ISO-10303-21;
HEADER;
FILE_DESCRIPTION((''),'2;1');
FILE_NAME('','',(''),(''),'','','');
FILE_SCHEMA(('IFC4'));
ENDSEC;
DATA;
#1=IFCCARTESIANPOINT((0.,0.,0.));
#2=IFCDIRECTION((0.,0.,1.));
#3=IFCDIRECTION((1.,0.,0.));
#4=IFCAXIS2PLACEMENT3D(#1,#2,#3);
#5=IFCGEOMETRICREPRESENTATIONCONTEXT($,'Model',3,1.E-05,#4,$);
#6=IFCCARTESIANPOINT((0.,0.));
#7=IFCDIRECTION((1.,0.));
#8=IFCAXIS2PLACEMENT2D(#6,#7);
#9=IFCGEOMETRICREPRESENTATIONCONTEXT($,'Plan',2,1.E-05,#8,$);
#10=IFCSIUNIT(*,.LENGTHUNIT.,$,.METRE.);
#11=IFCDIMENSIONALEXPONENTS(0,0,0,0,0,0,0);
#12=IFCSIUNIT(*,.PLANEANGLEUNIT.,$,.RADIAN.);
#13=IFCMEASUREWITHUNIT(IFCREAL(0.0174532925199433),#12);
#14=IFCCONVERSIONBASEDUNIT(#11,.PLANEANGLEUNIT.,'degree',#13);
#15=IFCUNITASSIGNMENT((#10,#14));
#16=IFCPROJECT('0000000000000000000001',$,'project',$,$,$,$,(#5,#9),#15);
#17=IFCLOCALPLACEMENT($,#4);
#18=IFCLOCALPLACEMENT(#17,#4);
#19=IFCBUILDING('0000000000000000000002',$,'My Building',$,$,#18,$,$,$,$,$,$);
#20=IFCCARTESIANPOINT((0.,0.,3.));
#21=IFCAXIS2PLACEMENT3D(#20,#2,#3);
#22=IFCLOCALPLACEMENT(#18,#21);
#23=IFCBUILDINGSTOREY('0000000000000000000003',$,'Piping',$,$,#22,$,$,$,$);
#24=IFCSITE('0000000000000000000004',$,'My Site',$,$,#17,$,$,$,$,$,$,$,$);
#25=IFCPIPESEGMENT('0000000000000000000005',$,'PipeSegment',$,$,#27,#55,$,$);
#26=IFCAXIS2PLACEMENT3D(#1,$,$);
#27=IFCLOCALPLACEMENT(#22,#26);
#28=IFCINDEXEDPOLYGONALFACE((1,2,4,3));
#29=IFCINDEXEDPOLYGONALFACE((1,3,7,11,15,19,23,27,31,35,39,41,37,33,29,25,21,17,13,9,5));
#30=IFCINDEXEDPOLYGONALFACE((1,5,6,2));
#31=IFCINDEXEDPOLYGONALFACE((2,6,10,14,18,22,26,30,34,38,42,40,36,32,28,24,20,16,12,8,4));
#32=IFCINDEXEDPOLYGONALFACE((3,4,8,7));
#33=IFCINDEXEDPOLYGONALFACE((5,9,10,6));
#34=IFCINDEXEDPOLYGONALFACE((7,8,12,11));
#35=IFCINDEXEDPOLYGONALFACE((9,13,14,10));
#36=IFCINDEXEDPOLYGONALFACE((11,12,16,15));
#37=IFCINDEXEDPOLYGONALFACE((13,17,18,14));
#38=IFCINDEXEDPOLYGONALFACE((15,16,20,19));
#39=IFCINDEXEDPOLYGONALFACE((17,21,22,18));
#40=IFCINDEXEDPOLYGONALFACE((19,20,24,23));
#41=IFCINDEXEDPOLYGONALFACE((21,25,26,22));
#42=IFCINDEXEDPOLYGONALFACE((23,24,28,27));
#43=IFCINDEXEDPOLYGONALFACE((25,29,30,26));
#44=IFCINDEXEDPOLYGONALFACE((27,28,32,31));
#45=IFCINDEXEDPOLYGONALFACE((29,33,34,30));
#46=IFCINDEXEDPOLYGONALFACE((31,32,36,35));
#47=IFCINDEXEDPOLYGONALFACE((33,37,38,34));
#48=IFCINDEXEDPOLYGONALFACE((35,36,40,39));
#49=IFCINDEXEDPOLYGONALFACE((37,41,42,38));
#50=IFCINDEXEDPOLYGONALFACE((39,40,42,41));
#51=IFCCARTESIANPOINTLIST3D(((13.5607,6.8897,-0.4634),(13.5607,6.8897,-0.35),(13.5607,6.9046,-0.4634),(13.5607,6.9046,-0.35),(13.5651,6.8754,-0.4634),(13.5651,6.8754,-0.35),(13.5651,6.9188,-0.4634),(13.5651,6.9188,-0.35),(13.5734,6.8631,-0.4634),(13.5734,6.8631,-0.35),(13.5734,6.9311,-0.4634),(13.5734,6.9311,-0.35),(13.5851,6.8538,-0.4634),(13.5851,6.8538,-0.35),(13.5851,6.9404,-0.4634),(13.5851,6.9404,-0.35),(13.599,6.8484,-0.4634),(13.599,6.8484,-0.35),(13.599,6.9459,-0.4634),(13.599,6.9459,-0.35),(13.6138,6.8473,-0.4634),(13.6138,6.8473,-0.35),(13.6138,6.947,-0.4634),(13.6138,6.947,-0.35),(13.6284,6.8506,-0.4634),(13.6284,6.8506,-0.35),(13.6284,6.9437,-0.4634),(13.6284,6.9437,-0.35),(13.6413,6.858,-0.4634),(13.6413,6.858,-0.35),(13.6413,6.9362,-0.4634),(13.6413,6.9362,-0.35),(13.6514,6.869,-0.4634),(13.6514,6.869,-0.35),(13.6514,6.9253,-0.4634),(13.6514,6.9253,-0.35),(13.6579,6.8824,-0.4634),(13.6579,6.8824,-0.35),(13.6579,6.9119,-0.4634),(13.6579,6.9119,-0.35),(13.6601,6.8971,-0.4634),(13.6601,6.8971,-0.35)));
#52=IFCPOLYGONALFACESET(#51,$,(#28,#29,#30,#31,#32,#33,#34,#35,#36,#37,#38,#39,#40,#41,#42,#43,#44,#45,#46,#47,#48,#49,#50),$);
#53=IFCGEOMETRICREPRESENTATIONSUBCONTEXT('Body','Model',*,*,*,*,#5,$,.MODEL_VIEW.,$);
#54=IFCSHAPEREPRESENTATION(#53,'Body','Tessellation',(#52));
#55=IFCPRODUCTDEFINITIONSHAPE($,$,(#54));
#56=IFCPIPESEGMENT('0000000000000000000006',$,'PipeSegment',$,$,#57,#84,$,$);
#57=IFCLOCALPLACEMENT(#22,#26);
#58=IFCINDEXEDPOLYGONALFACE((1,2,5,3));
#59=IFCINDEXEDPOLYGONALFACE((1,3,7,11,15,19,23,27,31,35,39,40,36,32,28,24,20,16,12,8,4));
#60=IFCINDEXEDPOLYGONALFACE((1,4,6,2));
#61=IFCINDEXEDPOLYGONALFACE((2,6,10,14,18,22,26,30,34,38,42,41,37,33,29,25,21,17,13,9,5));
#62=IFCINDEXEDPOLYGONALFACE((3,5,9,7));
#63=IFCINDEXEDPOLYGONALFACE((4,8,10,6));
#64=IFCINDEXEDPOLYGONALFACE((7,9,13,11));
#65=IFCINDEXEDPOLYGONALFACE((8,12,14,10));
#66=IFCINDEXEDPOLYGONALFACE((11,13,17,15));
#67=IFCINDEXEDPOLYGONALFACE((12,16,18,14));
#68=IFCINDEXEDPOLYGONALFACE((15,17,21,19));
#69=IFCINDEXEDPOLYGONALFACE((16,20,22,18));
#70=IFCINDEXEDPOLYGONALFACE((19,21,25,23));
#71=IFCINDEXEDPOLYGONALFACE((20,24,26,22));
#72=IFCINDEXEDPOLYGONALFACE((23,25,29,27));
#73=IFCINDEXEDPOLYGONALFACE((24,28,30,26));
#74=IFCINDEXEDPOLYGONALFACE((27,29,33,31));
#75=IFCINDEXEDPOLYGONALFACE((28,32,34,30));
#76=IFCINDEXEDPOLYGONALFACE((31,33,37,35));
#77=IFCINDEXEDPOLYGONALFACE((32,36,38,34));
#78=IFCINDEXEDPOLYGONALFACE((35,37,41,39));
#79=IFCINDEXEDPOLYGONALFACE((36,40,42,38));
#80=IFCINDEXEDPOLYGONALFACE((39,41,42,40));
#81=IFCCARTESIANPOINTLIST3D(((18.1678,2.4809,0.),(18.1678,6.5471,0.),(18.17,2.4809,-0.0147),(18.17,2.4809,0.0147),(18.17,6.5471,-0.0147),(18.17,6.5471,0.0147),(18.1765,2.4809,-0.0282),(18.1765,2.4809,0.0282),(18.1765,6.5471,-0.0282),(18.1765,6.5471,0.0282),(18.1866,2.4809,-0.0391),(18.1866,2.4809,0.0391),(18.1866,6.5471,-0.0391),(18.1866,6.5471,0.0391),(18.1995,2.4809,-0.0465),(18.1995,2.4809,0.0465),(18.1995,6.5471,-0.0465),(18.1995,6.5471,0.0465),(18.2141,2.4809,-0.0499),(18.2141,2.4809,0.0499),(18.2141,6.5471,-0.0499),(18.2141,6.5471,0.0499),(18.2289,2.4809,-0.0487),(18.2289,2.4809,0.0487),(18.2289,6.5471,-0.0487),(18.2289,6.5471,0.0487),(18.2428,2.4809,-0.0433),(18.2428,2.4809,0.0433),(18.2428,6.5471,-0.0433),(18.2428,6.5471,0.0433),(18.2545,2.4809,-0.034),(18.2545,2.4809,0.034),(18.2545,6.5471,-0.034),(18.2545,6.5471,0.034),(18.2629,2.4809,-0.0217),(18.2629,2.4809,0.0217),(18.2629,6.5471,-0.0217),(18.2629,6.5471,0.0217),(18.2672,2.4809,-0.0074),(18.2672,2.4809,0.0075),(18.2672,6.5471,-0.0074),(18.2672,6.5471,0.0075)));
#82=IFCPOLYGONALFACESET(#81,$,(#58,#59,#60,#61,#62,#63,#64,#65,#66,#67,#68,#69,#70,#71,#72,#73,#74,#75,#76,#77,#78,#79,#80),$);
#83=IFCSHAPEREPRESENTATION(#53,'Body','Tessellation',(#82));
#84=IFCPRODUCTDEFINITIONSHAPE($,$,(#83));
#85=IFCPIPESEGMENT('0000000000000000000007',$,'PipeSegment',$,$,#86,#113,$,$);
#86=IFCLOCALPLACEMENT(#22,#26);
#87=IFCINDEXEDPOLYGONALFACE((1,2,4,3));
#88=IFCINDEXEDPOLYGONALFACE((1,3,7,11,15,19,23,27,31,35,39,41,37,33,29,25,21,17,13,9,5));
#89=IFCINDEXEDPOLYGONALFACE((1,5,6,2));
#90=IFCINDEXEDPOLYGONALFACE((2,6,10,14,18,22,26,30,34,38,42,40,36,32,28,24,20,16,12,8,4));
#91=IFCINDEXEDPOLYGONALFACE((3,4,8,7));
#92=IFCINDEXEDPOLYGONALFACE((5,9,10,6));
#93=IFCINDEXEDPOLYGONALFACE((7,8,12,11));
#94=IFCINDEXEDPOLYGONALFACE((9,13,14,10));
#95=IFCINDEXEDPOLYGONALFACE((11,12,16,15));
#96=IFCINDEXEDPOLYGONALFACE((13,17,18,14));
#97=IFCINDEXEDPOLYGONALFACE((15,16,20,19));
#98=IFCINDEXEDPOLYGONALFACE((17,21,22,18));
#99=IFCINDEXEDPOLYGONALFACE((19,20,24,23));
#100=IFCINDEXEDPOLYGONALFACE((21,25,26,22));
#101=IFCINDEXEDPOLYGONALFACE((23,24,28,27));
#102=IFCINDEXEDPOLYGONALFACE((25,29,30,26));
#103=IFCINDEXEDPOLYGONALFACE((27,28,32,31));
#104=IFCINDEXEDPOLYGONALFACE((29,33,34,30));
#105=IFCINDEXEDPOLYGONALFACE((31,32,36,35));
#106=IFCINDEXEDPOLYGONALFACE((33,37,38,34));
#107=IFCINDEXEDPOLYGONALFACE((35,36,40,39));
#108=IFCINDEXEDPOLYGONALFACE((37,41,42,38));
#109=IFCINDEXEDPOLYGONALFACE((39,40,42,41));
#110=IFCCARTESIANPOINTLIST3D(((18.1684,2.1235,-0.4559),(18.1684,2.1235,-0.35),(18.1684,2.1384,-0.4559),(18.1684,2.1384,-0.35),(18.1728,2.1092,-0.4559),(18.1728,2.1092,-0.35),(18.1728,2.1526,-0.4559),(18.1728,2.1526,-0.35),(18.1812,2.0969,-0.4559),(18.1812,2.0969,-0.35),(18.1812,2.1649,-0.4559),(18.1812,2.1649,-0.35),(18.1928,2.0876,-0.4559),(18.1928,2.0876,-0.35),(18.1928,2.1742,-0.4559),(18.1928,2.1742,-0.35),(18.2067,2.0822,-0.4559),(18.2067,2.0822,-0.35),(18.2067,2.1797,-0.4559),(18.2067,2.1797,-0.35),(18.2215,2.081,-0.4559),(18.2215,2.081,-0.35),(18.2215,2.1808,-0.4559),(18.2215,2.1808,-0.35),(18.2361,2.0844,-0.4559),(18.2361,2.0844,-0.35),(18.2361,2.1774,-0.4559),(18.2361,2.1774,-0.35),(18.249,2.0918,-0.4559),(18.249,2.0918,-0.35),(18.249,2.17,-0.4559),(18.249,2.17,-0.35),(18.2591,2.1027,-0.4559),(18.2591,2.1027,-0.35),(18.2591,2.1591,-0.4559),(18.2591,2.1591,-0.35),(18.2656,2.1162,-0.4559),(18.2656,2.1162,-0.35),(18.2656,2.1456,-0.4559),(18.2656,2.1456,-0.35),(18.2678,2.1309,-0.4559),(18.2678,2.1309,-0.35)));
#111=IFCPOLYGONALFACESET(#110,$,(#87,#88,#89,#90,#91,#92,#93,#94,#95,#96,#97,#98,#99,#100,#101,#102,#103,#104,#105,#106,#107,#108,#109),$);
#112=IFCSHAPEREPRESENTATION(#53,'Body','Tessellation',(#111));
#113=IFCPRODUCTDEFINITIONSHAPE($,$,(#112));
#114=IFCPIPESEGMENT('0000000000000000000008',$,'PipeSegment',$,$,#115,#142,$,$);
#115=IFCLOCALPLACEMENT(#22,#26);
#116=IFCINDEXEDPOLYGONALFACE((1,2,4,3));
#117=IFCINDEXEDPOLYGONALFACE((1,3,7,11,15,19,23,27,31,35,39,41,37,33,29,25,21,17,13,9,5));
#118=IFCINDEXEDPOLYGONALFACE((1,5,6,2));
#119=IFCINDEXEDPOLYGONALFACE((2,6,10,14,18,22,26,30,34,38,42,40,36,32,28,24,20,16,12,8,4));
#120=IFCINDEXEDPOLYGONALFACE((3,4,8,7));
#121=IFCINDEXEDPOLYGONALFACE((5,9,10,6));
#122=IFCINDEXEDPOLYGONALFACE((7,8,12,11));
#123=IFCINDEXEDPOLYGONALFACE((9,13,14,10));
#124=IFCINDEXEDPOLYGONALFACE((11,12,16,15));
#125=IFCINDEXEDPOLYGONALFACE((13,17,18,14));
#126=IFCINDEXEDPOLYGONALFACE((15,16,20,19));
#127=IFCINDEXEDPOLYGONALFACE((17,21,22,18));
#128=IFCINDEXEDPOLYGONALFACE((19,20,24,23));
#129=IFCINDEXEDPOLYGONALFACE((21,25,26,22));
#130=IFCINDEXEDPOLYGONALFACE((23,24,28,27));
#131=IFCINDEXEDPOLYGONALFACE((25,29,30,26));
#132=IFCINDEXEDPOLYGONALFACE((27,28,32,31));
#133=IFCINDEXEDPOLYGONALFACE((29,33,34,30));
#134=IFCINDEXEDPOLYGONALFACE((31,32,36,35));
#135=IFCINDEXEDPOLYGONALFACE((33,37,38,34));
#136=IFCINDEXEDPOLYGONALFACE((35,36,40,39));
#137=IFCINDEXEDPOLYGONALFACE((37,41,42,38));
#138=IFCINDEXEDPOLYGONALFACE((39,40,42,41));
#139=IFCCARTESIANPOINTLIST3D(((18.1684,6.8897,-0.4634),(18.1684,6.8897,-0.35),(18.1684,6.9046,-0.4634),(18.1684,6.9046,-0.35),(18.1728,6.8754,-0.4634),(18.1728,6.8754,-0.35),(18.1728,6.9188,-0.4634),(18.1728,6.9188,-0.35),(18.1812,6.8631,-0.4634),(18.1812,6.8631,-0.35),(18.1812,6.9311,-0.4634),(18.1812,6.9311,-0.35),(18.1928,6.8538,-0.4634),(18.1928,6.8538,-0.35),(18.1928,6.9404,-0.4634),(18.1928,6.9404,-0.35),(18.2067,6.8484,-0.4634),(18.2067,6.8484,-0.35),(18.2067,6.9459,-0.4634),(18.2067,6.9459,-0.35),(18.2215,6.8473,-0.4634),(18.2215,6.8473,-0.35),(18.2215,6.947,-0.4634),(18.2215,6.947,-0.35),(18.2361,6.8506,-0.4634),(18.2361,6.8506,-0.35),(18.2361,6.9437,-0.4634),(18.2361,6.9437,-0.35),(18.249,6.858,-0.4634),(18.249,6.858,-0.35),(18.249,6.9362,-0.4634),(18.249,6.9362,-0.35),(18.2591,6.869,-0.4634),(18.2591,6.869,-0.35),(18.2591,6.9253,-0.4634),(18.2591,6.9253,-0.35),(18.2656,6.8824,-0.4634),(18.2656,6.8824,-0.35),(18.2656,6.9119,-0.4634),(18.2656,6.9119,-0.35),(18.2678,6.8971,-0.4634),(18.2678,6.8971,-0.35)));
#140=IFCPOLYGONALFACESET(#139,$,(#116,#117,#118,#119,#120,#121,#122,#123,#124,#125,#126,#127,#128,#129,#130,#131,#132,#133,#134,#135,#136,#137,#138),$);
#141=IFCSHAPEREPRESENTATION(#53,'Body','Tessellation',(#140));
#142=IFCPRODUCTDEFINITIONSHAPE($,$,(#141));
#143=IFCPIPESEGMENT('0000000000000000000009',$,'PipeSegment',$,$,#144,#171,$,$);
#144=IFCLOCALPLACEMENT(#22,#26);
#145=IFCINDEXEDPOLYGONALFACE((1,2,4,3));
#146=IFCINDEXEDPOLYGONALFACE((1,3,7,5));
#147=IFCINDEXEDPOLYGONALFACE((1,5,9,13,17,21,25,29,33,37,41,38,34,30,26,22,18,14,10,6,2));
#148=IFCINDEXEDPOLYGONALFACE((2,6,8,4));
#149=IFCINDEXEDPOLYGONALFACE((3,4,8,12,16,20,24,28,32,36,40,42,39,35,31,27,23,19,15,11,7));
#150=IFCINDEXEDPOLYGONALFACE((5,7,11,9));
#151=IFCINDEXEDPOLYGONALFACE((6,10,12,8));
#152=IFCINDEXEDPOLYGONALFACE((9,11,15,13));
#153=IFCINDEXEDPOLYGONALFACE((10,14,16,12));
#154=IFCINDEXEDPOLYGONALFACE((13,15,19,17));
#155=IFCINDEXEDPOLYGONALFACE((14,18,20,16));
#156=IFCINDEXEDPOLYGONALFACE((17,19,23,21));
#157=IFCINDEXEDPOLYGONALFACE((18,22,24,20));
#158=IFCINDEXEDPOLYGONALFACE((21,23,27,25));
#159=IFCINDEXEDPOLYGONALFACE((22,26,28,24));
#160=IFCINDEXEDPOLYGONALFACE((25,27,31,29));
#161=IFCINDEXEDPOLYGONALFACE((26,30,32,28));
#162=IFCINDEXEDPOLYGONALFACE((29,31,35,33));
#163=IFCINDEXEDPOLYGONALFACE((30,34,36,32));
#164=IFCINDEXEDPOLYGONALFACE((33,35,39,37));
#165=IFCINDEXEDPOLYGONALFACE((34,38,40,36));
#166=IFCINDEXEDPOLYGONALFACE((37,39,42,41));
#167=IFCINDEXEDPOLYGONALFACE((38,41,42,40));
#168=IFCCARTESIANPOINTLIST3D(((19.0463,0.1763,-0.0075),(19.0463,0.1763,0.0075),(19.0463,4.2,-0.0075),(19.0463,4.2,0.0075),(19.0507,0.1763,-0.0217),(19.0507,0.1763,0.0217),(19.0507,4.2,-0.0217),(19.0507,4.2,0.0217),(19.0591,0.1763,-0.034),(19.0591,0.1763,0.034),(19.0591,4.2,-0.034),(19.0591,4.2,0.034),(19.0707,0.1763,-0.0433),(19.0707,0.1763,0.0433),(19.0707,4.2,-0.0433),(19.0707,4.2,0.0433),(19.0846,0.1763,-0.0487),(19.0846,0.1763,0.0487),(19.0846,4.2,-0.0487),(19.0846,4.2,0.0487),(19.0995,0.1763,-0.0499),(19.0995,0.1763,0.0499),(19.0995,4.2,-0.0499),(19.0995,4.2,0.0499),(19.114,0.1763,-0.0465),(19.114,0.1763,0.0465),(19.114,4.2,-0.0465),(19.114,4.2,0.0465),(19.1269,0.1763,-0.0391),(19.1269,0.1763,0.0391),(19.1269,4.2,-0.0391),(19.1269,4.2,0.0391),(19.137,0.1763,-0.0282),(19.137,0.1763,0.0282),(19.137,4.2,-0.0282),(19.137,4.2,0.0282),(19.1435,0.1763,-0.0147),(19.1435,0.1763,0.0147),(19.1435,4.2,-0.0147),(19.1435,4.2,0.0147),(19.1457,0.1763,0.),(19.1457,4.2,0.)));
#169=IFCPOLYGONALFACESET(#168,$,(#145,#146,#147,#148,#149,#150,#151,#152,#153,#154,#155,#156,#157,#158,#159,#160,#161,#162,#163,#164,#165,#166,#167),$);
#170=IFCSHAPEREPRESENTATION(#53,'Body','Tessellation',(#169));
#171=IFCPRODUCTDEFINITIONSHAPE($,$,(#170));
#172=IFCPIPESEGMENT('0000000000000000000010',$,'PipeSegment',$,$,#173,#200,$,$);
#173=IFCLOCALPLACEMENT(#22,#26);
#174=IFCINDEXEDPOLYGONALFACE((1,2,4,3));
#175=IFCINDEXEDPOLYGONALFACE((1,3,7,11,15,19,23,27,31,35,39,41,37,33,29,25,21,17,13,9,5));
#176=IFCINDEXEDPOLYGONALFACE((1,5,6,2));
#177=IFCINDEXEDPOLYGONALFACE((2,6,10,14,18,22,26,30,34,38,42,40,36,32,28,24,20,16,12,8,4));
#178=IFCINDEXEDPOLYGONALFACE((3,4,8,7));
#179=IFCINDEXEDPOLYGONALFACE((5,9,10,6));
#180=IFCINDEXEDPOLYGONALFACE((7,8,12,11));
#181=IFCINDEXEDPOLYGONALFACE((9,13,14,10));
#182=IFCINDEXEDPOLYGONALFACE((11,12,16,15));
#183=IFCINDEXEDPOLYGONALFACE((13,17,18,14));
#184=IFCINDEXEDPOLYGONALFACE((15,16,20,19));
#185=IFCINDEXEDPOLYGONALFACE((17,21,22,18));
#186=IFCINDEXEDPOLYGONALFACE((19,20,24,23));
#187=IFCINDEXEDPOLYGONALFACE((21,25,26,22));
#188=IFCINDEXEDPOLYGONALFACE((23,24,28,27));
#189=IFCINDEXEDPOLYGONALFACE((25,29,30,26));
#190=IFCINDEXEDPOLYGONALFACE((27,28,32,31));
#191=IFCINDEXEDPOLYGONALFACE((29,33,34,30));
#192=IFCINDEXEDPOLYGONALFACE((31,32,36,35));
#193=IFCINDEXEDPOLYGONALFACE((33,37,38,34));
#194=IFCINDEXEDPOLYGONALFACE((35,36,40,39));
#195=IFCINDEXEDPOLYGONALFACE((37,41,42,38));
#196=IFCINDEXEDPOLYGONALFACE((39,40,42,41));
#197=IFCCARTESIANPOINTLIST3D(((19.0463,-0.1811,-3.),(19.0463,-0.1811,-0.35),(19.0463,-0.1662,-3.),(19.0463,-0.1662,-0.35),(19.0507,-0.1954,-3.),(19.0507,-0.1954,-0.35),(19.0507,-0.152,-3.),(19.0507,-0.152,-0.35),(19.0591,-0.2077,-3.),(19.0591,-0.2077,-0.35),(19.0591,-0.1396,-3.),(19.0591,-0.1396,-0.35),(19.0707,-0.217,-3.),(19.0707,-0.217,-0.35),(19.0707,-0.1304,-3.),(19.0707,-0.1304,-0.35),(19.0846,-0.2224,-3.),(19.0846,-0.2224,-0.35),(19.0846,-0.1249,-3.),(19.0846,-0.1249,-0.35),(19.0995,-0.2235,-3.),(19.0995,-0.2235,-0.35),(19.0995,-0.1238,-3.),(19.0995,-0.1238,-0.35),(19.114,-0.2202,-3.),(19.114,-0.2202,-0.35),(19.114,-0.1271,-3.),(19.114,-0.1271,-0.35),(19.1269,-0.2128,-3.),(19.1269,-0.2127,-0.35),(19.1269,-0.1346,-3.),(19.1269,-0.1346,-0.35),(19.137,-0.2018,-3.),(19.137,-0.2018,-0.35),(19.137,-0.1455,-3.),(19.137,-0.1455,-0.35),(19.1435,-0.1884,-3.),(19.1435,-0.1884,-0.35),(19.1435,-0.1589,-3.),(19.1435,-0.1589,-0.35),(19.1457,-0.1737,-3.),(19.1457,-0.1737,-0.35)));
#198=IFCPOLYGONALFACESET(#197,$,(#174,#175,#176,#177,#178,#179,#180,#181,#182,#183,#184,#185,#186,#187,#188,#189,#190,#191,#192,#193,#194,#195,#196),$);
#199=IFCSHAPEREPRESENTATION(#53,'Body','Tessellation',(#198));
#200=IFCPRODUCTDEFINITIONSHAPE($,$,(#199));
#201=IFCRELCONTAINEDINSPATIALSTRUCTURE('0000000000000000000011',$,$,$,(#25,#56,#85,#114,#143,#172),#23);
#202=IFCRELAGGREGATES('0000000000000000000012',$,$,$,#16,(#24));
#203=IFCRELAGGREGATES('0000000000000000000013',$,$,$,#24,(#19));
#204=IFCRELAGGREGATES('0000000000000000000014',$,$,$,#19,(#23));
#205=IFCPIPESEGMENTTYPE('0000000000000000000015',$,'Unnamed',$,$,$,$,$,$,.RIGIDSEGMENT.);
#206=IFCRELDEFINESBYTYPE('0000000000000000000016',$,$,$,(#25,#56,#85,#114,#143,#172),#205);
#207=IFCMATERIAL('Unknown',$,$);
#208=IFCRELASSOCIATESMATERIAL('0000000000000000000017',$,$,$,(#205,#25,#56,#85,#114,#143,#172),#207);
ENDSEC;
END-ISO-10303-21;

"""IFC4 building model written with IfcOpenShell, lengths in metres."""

from ifc_helpers import new_model, entity, si_unit, converted_unit, frame, origin_with_axes, origin_2d_with_axis, place, context, subcontext, project, spatial, circle, extrude, material, material_profile, profile_set, profile_usage, type_object, element, save


model = new_model("IFC4")

# Units and contexts
model_context = context("Model", 3, precision=1e-05, world=origin_with_axes())
plan_context = context("Plan", 2, precision=1e-05, world=origin_2d_with_axis())
body_context = subcontext(model_context, "Body", "Model", "MODEL_VIEW")
ifc_project = project(units=[si_unit("LENGTHUNIT", "METRE"), converted_unit("PLANEANGLEUNIT", "degree", entity("IfcReal", 0.0174532925199433), si_unit("PLANEANGLEUNIT", "RADIAN"), dimensions=[0, 0, 0, 0, 0, 0, 0])], contexts=[model_context, plan_context])

# Site, building, storey
site_placement = place(None, origin_with_axes())
site = spatial("IfcSite", under=ifc_project, at=site_placement, Name="My Site")
building_placement = place(site_placement, origin_with_axes())
building = spatial("IfcBuilding", under=site, at=building_placement, Name="My Building")
storey_placement = place(building_placement, frame((0.0, 0.0, 3.0), z_axis=(0.0, 0.0, 1.0), x_axis=(1.0, 0.0, 0.0)))
storey = spatial("IfcBuildingStorey", under=building, at=storey_placement, Name="Piping")

# Pipe segments
ifc_material = material(Name="Unknown")
ifc_material_profile = material_profile(ifc_material, circle(Radius=0.05))
ifc_profile_set = profile_set([ifc_material_profile])
pipe_segment_type = type_object("IfcPipeSegmentType", Name="Unnamed", PredefinedType="RIGIDSEGMENT", material=ifc_profile_set)
ifc_profile_usage_1 = profile_usage(ifc_profile_set, cardinal=5)
pipe_segment_1_placement = place(storey_placement, frame((13.6101, 6.8971, -0.35), z_axis=(0.0, 0.0, -1.0), x_axis=(1.0, 0.0, 0.0)))
element("IfcPipeSegment", 1, at=pipe_segment_1_placement, inside=storey, type_object=pipe_segment_type, material=ifc_profile_usage_1, Name="PipeSegment", context=body_context, shape_type="SweptSolid", body=[
    extrude(circle(Radius=0.05), origin_with_axes(), (0.0, 0.0, 1.0), 0.1134),
])
ifc_profile_usage_2 = profile_usage(ifc_profile_set, cardinal=5)
pipe_segment_2_placement = place(storey_placement, frame((18.2178, 2.4809, 0.0), z_axis=(0.0, 1.0, 0.0), x_axis=(-1.0, 0.0, 0.0)))
element("IfcPipeSegment", 2, at=pipe_segment_2_placement, inside=storey, type_object=pipe_segment_type, material=ifc_profile_usage_2, Name="PipeSegment", context=body_context, shape_type="SweptSolid", body=[
    extrude(circle(Radius=0.05), origin_with_axes(), (0.0, 0.0, 1.0), 4.0662),
])
ifc_profile_usage_3 = profile_usage(ifc_profile_set, cardinal=5)
pipe_segment_3_placement = place(storey_placement, frame((18.2178, 2.1309, -0.35), z_axis=(0.0, 0.0, -1.0), x_axis=(1.0, 0.0, 0.0)))
element("IfcPipeSegment", 3, at=pipe_segment_3_placement, inside=storey, type_object=pipe_segment_type, material=ifc_profile_usage_3, Name="PipeSegment", context=body_context, shape_type="SweptSolid", body=[
    extrude(circle(Radius=0.05), origin_with_axes(), (0.0, 0.0, 1.0), 0.1059),
])
ifc_profile_usage_4 = profile_usage(ifc_profile_set, cardinal=5)
pipe_segment_4_placement = place(storey_placement, frame((18.2178, 6.8971, -0.35), z_axis=(0.0, 0.0, -1.0), x_axis=(1.0, 0.0, 0.0)))
element("IfcPipeSegment", 4, at=pipe_segment_4_placement, inside=storey, type_object=pipe_segment_type, material=ifc_profile_usage_4, Name="PipeSegment", context=body_context, shape_type="SweptSolid", body=[
    extrude(circle(Radius=0.05), origin_with_axes(), (0.0, 0.0, 1.0), 0.1134),
])
ifc_profile_usage_5 = profile_usage(ifc_profile_set, cardinal=5)
pipe_segment_5_placement = place(storey_placement, frame((19.0957, 4.2, 0.0), z_axis=(0.0, -1.0, 0.0), x_axis=(1.0, 0.0, 0.0)))
element("IfcPipeSegment", 5, at=pipe_segment_5_placement, inside=storey, type_object=pipe_segment_type, material=ifc_profile_usage_5, Name="PipeSegment", context=body_context, shape_type="SweptSolid", body=[
    extrude(circle(Radius=0.05), origin_with_axes(), (0.0, 0.0, 1.0), 4.0237),
])
ifc_profile_usage_6 = profile_usage(ifc_profile_set, cardinal=5)
pipe_segment_6_placement = place(storey_placement, frame((19.0957, -0.1737, -0.35), z_axis=(0.0, 0.0, -1.0), x_axis=(1.0, 0.0, 0.0)))
element("IfcPipeSegment", 6, at=pipe_segment_6_placement, inside=storey, type_object=pipe_segment_type, material=ifc_profile_usage_6, Name="PipeSegment", context=body_context, shape_type="SweptSolid", body=[
    extrude(circle(Radius=0.05), origin_with_axes(), (0.0, 0.0, 1.0), 2.65),
])

save(model, "model.ifc")
